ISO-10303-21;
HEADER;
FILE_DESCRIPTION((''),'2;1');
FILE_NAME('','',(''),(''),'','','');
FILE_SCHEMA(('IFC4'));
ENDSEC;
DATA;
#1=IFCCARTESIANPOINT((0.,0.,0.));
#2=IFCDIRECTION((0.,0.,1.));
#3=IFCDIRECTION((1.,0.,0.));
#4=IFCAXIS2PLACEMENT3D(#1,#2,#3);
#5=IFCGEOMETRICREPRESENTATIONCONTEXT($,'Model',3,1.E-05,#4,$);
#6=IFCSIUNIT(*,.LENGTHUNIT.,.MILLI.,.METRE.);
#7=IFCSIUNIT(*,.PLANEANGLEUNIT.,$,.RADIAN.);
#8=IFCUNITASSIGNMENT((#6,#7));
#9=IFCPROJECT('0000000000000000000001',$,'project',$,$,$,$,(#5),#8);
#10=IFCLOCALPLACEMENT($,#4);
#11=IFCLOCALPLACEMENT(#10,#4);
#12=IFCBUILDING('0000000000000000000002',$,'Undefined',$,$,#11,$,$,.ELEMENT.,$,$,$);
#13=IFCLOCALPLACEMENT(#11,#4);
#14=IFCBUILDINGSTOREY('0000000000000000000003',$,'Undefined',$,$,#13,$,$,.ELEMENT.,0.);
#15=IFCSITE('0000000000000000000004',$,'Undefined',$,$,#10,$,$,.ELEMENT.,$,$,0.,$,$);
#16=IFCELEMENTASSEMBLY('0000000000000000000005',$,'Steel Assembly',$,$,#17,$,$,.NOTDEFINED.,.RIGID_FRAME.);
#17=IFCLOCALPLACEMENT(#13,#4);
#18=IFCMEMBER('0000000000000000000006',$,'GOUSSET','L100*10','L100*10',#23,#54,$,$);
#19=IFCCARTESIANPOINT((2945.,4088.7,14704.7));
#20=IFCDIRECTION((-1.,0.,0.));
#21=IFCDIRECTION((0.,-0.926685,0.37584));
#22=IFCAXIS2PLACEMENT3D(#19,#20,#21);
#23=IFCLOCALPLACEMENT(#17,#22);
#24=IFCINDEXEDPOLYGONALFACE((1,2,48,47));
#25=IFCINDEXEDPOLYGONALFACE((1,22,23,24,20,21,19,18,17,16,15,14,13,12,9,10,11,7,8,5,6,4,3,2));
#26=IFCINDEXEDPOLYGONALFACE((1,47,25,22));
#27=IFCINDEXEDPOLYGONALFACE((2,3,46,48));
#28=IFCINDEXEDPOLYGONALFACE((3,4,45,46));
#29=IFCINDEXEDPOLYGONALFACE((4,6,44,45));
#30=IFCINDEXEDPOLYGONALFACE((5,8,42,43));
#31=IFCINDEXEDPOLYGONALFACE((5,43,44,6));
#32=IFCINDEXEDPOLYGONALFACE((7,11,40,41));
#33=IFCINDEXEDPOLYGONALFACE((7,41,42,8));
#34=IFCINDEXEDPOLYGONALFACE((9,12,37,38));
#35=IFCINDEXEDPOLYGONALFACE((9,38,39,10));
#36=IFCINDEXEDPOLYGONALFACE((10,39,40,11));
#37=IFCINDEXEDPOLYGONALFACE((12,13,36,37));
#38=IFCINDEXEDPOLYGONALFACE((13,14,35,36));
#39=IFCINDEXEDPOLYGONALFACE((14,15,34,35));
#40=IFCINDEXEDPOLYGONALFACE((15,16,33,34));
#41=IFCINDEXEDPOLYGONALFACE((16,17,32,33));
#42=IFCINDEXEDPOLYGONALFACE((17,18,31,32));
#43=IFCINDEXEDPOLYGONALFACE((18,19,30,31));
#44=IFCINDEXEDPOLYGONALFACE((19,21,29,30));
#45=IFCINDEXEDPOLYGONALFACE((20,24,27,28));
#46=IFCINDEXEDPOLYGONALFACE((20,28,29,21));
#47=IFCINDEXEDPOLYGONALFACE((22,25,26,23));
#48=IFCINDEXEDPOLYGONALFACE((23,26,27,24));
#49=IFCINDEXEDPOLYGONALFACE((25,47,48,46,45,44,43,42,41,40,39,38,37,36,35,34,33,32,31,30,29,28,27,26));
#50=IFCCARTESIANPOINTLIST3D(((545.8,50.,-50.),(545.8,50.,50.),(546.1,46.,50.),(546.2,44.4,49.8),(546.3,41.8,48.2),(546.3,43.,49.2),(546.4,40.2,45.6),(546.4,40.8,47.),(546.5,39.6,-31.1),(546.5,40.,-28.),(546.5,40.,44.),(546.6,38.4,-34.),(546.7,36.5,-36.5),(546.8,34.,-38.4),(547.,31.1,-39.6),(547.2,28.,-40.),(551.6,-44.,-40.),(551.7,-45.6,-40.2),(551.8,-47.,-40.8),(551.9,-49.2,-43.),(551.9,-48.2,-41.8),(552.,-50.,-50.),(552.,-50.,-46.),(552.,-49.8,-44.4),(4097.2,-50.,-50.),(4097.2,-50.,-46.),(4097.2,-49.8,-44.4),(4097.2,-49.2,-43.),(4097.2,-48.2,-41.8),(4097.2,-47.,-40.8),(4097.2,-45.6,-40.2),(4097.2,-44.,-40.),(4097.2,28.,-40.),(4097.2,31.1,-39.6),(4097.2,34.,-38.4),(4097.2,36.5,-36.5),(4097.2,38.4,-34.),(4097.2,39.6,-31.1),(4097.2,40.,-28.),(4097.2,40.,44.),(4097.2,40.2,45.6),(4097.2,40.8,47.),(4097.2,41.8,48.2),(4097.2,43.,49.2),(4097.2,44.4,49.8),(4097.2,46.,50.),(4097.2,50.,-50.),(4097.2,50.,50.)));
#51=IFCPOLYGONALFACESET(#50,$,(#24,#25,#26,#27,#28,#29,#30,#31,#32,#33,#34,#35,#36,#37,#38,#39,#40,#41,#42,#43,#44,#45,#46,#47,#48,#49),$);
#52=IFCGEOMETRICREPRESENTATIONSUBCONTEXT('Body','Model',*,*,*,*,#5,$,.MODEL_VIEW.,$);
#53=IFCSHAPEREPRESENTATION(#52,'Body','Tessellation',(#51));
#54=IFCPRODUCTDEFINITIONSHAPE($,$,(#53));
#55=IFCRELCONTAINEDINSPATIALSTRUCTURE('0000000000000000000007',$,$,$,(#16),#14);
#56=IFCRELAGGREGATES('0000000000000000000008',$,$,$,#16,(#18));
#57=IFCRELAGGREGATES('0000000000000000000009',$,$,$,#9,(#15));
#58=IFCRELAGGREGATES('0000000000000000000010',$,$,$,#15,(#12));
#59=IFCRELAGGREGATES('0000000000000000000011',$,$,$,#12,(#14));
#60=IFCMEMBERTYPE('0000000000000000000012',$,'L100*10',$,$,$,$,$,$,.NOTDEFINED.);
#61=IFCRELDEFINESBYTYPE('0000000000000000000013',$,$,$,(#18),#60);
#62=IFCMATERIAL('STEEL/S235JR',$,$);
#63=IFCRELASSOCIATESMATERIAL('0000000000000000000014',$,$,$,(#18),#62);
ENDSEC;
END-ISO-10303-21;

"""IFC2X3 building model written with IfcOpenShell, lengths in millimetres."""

from ifc_helpers import new_model, si_unit, frame, origin_with_axes, origin_2d_with_axis, place, context, subcontext, project, spatial, l_section, extrude, clip, halfspace, material, type_object, element, aggregate, save


model = new_model("IFC2X3")

# Units and contexts
model_context = context("Model", 3, precision=1e-05, world=origin_with_axes())
body_context = subcontext(model_context, "Body", "Model", "MODEL_VIEW")
ifc_project = project(units=[si_unit("LENGTHUNIT", "METRE", prefix="MILLI"), si_unit("PLANEANGLEUNIT", "RADIAN")], contexts=[model_context])

# Site, building, storey
site_placement = place(None, origin_with_axes())
site = spatial("IfcSite", under=ifc_project, at=site_placement, Name="Undefined", CompositionType="ELEMENT", RefElevation=0.0)
building_placement = place(site_placement, origin_with_axes())
building = spatial("IfcBuilding", under=site, at=building_placement, Name="Undefined", CompositionType="ELEMENT")
storey_placement = place(building_placement, origin_with_axes())
storey = spatial("IfcBuildingStorey", under=building, at=storey_placement, Name="Undefined", CompositionType="ELEMENT", Elevation=0.0)

# Shared definitions
ifc_material_1 = material(Name="STEEL/S235JR")

# Element assembly, member
assembly_1_placement = place(storey_placement, origin_with_axes())
assembly_1 = element("IfcElementAssembly", 1, at=assembly_1_placement, inside=storey, Name="Steel Assembly", AssemblyPlace="NOTDEFINED", PredefinedType="RIGID_FRAME")
member_type = type_object("IfcMemberType", Name="L100*10", PredefinedType="NOTDEFINED")
member_1_placement = place(assembly_1_placement, frame((2945.0, 4088.7, 14704.7), z_axis=(-1.0, 0.0, 0.0), x_axis=(0.0, -0.926685, 0.37584)))
member_1 = element("IfcMember", 2, at=member_1_placement, type_object=member_type, material=ifc_material_1, Name="GOUSSET", Description="L100*10", ObjectType="L100*10", context=body_context, shape_type="Clipping", body=[
    clip(extrude(l_section(Depth=100.0, Width=100.0, Thickness=10.0, FilletRadius=12.0, EdgeRadius=6.0, at=origin_2d_with_axis()), frame((4097.2, 0.0, 0.0), z_axis=(-1.0, 0.0, 0.0), x_axis=(0.0, -1.0, 0.0)), (0.0, 0.0, 1.0), 3620.9), halfspace(frame((535.3, 221.5, 0.0), z_axis=(-0.998108, -0.061479, 0.0), x_axis=(0.0, 0.0, 1.0)), False)),
])
aggregate(assembly_1, [member_1])

save(model, "model.ifc")
